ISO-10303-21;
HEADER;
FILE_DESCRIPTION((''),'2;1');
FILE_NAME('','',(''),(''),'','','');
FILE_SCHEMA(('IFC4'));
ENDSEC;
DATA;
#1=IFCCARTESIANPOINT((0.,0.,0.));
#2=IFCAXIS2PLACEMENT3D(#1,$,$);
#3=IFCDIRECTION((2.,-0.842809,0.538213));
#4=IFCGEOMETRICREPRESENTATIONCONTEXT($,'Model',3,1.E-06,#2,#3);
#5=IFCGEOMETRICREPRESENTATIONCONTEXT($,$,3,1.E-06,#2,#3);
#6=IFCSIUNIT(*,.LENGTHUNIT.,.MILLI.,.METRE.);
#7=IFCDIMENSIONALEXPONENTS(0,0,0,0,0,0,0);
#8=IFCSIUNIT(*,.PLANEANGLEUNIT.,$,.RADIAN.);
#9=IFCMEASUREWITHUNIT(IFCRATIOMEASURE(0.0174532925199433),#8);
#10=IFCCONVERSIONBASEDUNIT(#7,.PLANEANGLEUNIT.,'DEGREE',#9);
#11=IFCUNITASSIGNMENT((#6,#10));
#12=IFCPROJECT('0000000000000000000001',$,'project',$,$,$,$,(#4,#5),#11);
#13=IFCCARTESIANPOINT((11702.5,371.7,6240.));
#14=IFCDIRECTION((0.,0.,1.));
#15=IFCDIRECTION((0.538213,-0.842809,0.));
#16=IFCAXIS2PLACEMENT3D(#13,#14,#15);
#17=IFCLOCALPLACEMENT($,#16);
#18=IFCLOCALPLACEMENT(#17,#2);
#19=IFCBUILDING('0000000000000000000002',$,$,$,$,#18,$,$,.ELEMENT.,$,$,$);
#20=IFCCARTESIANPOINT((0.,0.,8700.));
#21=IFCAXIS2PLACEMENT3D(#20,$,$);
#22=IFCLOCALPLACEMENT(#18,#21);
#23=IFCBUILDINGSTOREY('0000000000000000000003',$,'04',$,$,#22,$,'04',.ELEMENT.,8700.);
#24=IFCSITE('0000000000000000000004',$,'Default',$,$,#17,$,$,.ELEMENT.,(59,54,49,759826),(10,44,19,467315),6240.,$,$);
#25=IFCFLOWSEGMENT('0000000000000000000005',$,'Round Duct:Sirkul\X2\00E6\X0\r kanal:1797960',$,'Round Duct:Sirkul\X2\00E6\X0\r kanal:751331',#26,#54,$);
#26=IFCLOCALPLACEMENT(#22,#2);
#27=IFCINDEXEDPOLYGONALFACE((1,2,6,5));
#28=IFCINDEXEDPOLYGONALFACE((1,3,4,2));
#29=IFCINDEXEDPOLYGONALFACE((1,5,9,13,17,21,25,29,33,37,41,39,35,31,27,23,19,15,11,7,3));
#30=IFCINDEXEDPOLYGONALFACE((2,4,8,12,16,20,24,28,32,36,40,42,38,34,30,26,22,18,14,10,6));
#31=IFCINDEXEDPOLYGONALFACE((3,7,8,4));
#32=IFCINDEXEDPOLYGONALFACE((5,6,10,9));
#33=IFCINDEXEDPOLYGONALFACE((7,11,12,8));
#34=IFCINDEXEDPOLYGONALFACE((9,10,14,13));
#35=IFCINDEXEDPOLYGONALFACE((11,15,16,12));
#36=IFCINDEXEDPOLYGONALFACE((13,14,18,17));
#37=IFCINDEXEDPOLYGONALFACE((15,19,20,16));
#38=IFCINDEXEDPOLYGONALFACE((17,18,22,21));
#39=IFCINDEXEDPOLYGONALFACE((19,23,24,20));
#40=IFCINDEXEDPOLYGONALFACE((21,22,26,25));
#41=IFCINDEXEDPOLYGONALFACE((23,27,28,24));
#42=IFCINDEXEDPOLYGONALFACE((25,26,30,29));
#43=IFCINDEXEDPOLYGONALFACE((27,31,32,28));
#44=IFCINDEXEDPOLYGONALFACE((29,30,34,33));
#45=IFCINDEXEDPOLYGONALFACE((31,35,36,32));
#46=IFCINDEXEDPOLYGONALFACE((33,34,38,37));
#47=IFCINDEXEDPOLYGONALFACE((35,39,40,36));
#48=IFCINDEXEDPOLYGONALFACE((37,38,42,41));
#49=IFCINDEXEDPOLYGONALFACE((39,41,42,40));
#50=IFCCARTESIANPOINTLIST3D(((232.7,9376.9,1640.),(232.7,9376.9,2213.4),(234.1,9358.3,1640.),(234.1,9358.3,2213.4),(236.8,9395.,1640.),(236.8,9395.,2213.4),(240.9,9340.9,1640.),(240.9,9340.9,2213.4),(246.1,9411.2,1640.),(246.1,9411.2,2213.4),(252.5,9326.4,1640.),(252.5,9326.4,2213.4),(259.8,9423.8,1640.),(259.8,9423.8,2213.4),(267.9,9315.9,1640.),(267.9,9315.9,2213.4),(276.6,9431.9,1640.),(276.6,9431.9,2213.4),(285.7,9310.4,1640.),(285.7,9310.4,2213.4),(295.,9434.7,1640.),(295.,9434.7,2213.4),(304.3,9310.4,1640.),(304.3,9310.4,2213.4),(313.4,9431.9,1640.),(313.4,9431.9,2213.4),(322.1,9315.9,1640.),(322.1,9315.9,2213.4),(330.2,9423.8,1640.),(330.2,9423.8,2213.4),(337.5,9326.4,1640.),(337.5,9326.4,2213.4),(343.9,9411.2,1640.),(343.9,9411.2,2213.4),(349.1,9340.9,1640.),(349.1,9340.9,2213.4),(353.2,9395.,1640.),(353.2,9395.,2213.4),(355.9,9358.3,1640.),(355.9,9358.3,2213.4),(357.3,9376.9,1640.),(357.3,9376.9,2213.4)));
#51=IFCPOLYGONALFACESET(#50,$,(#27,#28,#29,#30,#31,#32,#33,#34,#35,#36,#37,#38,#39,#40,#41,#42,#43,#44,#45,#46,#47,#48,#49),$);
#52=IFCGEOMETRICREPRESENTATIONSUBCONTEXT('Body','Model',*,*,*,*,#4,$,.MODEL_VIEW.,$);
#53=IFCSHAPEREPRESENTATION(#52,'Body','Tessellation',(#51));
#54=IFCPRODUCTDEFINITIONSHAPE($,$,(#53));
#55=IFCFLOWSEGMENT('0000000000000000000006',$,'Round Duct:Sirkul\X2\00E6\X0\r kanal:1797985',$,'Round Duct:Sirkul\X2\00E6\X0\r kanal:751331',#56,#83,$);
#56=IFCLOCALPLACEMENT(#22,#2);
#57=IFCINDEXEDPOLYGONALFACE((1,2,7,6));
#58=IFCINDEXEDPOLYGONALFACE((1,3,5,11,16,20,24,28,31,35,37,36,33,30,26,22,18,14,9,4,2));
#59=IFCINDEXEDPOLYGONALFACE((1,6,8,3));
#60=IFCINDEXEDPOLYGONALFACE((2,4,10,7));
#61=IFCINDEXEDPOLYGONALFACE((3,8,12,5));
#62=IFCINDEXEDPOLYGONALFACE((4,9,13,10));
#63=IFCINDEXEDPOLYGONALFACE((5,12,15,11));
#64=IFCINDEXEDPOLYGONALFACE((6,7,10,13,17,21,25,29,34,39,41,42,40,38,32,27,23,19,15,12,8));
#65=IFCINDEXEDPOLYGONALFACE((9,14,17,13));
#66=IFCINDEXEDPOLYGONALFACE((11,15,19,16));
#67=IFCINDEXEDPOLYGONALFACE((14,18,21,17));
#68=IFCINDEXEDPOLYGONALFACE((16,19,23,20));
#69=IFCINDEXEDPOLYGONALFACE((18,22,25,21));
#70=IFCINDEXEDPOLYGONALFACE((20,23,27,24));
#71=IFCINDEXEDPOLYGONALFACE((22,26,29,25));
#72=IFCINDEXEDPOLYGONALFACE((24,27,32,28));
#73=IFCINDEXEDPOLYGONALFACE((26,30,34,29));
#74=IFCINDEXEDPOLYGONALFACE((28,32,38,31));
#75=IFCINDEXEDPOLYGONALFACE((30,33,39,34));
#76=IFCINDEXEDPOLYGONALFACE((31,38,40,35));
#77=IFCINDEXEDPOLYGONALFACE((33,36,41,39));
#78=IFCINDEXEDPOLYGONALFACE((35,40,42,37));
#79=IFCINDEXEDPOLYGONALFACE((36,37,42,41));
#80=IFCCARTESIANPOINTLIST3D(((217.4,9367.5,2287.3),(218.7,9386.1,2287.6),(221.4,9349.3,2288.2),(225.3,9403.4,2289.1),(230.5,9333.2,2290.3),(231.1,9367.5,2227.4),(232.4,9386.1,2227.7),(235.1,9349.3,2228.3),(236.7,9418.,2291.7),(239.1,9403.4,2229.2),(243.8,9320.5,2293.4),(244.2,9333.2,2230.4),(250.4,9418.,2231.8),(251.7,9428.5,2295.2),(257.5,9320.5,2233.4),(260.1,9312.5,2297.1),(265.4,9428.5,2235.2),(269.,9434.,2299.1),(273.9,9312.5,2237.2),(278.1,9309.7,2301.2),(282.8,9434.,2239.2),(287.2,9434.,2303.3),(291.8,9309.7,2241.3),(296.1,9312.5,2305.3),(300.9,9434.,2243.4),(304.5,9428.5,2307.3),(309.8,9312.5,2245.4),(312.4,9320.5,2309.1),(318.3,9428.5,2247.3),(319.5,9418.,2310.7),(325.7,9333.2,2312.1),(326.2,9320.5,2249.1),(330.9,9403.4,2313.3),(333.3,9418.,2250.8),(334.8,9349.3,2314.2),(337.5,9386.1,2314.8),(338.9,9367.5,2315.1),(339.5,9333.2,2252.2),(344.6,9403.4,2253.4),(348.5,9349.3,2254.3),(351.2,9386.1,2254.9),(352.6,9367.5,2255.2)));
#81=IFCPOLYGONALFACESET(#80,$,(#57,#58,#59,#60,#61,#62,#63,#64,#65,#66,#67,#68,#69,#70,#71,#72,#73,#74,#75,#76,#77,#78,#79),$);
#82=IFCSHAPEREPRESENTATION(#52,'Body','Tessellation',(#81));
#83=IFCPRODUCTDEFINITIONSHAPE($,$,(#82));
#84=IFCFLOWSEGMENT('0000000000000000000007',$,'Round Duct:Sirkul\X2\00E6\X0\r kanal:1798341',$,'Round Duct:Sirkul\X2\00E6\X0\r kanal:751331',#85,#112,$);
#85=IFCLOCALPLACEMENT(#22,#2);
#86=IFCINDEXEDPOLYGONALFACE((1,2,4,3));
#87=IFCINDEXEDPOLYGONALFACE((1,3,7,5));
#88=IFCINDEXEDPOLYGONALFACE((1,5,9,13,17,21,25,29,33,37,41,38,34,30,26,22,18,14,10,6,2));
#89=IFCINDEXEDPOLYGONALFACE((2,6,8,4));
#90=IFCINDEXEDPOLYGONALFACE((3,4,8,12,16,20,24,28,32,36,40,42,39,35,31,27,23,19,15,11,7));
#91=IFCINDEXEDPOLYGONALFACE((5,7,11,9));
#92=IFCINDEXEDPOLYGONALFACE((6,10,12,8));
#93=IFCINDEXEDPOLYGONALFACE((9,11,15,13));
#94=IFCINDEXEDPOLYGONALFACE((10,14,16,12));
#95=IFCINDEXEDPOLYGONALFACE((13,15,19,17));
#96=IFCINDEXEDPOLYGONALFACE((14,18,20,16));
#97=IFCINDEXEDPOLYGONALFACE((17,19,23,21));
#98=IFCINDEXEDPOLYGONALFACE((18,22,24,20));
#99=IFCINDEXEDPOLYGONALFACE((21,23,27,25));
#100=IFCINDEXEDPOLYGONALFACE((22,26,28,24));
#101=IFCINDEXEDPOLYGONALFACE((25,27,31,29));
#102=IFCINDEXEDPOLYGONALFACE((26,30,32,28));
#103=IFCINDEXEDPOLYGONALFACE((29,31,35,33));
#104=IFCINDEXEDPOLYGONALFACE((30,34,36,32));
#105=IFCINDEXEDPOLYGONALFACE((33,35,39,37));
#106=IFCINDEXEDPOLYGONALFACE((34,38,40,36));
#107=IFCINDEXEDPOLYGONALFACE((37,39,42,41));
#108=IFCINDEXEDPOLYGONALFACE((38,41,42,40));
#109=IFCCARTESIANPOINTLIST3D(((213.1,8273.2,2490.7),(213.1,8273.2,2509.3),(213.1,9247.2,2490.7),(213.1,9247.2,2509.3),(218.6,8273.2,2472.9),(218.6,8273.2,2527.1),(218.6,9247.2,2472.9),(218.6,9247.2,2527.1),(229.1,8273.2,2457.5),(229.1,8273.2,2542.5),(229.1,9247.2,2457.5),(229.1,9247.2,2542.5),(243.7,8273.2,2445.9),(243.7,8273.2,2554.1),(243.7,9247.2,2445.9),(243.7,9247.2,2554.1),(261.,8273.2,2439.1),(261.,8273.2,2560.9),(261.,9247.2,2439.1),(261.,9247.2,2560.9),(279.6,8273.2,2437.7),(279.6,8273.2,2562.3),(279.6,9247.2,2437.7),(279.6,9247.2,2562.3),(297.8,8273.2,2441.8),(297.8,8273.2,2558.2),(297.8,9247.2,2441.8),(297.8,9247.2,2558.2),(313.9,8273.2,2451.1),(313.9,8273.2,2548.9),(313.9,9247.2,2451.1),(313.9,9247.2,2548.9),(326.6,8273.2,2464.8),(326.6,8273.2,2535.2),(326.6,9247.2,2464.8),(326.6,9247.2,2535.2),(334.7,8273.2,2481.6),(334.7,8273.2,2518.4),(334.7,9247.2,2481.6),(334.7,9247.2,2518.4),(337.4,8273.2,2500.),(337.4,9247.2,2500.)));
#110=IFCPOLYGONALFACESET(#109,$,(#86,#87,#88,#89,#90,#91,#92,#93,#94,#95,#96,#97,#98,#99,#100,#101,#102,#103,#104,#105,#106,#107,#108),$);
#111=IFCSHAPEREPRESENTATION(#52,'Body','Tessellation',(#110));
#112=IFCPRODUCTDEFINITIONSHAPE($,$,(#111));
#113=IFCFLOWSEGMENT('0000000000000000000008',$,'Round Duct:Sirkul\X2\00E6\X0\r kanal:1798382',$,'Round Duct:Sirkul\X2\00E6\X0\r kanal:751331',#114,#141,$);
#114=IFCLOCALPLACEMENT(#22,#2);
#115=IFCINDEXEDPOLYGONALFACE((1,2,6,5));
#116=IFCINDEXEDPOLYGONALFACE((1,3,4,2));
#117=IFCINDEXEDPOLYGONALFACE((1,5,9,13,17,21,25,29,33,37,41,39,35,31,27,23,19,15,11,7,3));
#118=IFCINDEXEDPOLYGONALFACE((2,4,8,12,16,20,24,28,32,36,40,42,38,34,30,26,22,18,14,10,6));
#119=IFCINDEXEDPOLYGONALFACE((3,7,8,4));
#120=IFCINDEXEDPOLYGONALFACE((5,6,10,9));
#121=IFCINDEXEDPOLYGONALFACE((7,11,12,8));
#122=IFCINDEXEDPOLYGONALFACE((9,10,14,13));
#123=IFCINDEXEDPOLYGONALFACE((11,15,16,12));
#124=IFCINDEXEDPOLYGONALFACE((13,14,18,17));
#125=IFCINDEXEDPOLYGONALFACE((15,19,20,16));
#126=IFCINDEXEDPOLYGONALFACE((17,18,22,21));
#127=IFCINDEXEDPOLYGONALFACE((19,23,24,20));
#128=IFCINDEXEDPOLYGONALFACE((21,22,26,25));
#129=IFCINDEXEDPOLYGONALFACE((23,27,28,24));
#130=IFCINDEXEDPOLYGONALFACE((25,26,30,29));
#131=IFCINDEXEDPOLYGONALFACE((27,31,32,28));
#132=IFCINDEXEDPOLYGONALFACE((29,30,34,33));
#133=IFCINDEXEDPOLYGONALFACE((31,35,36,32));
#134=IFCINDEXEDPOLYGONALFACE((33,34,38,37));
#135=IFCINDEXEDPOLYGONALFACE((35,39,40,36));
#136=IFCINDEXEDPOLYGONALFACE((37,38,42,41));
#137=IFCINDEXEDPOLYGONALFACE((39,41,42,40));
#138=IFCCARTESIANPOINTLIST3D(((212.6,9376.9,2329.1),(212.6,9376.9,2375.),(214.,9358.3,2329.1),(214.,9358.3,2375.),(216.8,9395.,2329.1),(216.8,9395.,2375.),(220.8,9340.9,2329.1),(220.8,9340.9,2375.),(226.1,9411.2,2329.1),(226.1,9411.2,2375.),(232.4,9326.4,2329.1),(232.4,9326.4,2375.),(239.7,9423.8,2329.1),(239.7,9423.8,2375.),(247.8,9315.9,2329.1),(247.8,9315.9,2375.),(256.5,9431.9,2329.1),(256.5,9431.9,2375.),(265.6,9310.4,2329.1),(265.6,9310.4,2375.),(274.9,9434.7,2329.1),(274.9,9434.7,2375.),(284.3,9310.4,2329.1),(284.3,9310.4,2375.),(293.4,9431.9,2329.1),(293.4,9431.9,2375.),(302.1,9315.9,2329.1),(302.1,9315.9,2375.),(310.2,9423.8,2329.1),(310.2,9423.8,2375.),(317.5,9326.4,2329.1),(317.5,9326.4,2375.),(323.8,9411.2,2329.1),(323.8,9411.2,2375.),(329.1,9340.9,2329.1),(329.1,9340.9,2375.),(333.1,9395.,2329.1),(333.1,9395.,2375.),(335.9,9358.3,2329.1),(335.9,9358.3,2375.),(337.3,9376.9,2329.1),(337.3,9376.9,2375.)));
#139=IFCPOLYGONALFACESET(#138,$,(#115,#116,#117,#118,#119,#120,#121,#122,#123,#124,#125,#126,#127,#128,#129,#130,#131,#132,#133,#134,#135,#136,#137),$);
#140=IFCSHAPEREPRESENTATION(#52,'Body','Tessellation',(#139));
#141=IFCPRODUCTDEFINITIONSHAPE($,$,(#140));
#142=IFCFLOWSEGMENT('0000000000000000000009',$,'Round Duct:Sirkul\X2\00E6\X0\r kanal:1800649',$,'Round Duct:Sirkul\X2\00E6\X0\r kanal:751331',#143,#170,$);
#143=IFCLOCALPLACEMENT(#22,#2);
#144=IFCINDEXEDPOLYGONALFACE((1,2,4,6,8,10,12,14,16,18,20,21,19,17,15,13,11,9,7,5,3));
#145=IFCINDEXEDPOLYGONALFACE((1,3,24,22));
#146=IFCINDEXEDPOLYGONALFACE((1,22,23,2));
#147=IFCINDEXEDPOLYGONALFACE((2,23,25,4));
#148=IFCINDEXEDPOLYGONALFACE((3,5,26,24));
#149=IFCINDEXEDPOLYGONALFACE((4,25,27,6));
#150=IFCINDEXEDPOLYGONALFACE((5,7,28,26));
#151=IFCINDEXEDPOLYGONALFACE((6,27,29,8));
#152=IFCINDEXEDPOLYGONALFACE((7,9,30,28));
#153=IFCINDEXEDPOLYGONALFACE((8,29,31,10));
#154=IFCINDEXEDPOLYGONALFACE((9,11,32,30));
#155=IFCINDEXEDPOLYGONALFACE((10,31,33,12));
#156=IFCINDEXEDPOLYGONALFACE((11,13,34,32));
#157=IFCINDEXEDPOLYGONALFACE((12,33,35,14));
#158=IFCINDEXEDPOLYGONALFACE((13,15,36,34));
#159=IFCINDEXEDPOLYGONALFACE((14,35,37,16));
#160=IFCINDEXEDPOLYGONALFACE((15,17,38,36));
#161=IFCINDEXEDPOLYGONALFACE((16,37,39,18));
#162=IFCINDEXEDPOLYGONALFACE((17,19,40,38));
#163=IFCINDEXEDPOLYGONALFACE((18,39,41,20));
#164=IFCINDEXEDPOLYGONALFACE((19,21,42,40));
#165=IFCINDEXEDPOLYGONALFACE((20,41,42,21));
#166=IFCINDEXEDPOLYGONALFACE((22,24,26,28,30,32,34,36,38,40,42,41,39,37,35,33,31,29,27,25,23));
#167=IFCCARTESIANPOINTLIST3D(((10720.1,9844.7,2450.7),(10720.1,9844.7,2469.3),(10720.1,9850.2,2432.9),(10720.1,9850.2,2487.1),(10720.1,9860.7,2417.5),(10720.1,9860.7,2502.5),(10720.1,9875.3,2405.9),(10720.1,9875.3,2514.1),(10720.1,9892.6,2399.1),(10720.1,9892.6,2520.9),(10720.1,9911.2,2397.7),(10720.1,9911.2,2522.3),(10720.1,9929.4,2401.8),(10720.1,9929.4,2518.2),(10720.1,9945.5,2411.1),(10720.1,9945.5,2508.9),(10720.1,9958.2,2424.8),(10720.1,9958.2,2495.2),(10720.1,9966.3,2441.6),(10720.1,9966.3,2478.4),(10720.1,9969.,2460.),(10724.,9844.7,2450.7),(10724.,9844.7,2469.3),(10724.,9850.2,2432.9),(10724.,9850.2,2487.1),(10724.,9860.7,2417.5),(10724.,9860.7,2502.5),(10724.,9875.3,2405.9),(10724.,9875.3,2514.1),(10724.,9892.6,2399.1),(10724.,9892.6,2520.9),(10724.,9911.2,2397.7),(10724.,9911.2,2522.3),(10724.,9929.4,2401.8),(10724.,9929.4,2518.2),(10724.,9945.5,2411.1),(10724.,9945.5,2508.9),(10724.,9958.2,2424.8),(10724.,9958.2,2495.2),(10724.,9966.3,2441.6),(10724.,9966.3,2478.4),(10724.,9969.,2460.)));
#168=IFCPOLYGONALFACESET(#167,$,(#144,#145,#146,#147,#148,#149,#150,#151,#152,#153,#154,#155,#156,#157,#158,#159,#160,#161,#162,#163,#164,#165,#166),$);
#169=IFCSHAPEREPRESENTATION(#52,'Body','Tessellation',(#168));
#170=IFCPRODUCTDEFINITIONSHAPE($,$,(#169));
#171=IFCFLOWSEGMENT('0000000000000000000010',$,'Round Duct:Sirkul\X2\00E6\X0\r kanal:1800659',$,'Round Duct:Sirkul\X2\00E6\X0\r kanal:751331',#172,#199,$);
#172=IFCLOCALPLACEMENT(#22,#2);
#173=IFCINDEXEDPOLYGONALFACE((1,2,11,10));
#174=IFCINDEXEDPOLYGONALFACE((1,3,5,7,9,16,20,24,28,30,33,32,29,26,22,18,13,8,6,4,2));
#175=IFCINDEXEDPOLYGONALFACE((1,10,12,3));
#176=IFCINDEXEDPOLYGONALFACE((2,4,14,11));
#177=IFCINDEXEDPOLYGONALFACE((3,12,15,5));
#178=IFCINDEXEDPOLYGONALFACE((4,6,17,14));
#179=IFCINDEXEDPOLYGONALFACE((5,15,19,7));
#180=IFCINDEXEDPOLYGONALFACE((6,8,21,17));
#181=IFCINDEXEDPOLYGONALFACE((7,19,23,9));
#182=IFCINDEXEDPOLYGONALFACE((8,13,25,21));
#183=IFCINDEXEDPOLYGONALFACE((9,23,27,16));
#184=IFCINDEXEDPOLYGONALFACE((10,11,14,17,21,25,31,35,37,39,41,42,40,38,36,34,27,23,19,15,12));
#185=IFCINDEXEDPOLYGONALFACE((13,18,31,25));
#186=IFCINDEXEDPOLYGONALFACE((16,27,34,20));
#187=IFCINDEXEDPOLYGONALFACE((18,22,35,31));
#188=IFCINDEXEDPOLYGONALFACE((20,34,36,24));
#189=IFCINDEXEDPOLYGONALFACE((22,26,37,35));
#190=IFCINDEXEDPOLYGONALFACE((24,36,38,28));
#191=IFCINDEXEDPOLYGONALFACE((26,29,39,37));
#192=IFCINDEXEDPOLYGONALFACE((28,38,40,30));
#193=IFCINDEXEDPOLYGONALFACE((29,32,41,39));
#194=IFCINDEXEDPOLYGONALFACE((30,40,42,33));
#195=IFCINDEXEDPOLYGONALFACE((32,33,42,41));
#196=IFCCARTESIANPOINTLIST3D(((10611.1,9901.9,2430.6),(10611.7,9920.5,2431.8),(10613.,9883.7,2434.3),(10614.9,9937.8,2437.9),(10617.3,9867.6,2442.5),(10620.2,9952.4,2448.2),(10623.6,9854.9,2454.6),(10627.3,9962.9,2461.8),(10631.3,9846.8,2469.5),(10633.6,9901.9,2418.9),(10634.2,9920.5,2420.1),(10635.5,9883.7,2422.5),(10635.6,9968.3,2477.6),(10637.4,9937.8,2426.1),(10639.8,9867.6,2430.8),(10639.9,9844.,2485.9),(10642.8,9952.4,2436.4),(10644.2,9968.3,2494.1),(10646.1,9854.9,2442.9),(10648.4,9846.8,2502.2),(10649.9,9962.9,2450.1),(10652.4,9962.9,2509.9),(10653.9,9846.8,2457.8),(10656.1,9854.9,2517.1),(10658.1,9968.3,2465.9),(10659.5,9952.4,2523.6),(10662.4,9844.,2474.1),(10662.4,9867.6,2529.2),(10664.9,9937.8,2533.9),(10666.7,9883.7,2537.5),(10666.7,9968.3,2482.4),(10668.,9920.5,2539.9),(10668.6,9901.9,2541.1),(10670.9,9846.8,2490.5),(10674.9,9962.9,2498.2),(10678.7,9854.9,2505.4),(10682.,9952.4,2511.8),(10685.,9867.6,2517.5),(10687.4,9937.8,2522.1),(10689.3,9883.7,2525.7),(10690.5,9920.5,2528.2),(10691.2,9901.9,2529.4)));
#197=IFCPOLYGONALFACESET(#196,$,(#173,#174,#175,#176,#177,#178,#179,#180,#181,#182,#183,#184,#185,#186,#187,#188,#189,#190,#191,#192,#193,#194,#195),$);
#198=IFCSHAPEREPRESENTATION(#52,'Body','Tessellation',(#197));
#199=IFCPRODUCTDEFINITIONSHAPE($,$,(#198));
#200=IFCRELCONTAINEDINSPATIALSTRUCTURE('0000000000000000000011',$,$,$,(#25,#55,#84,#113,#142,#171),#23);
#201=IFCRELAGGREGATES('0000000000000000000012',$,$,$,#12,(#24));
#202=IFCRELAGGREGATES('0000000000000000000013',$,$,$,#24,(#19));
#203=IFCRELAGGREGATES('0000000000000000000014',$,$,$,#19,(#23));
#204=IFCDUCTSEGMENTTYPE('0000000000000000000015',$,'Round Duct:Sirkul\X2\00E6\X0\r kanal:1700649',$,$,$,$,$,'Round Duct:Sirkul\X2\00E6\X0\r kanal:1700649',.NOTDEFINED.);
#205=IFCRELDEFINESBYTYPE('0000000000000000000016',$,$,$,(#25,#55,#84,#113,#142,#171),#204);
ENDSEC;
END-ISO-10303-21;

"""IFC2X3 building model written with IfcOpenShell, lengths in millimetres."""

from ifc_helpers import new_model, entity, si_unit, converted_unit, direction, frame, frame_2d, origin, origin_2d_with_axis, place, context, subcontext, project, spatial, circle, extrude, type_object, element, save


model = new_model("IFC2X3")

# Units and contexts
model_context = context("Model", 3, precision=1e-06, world=origin(), true_north=direction((2.0, -0.842809, 0.538213)))
context_of_model = context(None, 3, precision=1e-06, world=origin(), true_north=direction((2.0, -0.842809, 0.538213)))
body_context = subcontext(model_context, "Body", "Model", "MODEL_VIEW")
ifc_project = project(units=[si_unit("LENGTHUNIT", "METRE", prefix="MILLI"), converted_unit("PLANEANGLEUNIT", "DEGREE", entity("IfcRatioMeasure", 0.0174532925199433), si_unit("PLANEANGLEUNIT", "RADIAN"), dimensions=[0, 0, 0, 0, 0, 0, 0])], contexts=[model_context, context_of_model])

# Site, building, storey
site_placement = place(None, frame((11702.5, 371.7, 6240.0), z_axis=(0.0, 0.0, 1.0), x_axis=(0.538213, -0.842809, 0.0)))
site = spatial("IfcSite", under=ifc_project, at=site_placement, Name="Default", CompositionType="ELEMENT", RefLatitude=(59, 54, 49, 759826), RefLongitude=(10, 44, 19, 467315), RefElevation=6240.0)
building_placement = place(site_placement, origin())
building = spatial("IfcBuilding", under=site, at=building_placement, CompositionType="ELEMENT")
storey_placement = place(building_placement, frame((0.0, 0.0, 8700.0)))
storey = spatial("IfcBuildingStorey", under=building, at=storey_placement, Name="04", LongName="04", CompositionType="ELEMENT", Elevation=8700.0)

# Flow segments
duct_segment_type = type_object("IfcDuctSegmentType", Name="Round Duct:Sirkulær kanal:1700649", ElementType="Round Duct:Sirkulær kanal:1700649", PredefinedType="NOTDEFINED")
flow_segment_1_placement = place(storey_placement, origin())
element("IfcFlowSegment", 1, at=flow_segment_1_placement, inside=storey, type_object=duct_segment_type, Name="Round Duct:Sirkulær kanal:1797960", ObjectType="Round Duct:Sirkulær kanal:751331", context=body_context, shape_type="SweptSolid", body=[
    extrude(circle(Radius=62.5, at=frame_2d((0.0, 0.0), x_axis=(1.0, 0.0))), frame((295.0, 9372.2, 1640.0), z_axis=(0.0, 0.0, 1.0), x_axis=(0.0, 1.0, 0.0)), (0.0, 0.0, 1.0), 573.4),
])
flow_segment_2_placement = place(storey_placement, origin())
element("IfcFlowSegment", 2, at=flow_segment_2_placement, inside=storey, type_object=duct_segment_type, Name="Round Duct:Sirkulær kanal:1797985", ObjectType="Round Duct:Sirkulær kanal:751331", context=body_context, shape_type="SweptSolid", body=[
    extrude(circle(Radius=62.5, at=frame_2d((0.0, 0.0), x_axis=(1.0, 0.0))), frame((291.8, 9372.2, 2241.3), z_axis=(-0.223272, 0.0, 0.974756), x_axis=(0.0, -1.0, 0.0)), (0.0, 0.0, 1.0), 61.5),
])
flow_segment_3_placement = place(storey_placement, origin())
element("IfcFlowSegment", 3, at=flow_segment_3_placement, inside=storey, type_object=duct_segment_type, Name="Round Duct:Sirkulær kanal:1798341", ObjectType="Round Duct:Sirkulær kanal:751331", context=body_context, shape_type="SweptSolid", body=[
    extrude(circle(Radius=62.5, at=frame_2d((0.0, 0.0), x_axis=(1.0, 0.0))), frame((274.9, 8273.2, 2500.0), z_axis=(0.0, 1.0, 0.0), x_axis=(1.0, 0.0, 0.0)), (0.0, 0.0, 1.0), 974.0),
])
flow_segment_4_placement = place(storey_placement, origin())
element("IfcFlowSegment", 4, at=flow_segment_4_placement, inside=storey, type_object=duct_segment_type, Name="Round Duct:Sirkulær kanal:1798382", ObjectType="Round Duct:Sirkulær kanal:751331", context=body_context, shape_type="SweptSolid", body=[
    extrude(circle(Radius=62.5, at=frame_2d((0.0, 0.0), x_axis=(1.0, 0.0))), frame((274.9, 9372.2, 2329.1), z_axis=(0.0, 0.0, 1.0), x_axis=(0.0, 1.0, 0.0)), (0.0, 0.0, 1.0), 45.9),
])
flow_segment_5_placement = place(storey_placement, origin())
element("IfcFlowSegment", 5, at=flow_segment_5_placement, inside=storey, type_object=duct_segment_type, Name="Round Duct:Sirkulær kanal:1800649", ObjectType="Round Duct:Sirkulær kanal:751331", context=body_context, shape_type="SweptSolid", body=[
    extrude(circle(Radius=62.5, at=origin_2d_with_axis()), frame((10720.1, 9906.5, 2460.0), z_axis=(1.0, 0.0, 0.0), x_axis=(0.0, 1.0, 0.0)), (0.0, 0.0, 1.0), 3.8),
])
flow_segment_6_placement = place(storey_placement, origin())
element("IfcFlowSegment", 6, at=flow_segment_6_placement, inside=storey, type_object=duct_segment_type, Name="Round Duct:Sirkulær kanal:1800659", ObjectType="Round Duct:Sirkulær kanal:751331", context=body_context, shape_type="SweptSolid", body=[
    extrude(circle(Radius=62.5, at=origin_2d_with_axis()), frame((10639.9, 9906.5, 2485.9), z_axis=(0.886943, 0.0, -0.461878), x_axis=(0.0, -1.0, 0.0)), (0.0, 0.0, 1.0), 25.4),
])

save(model, "model.ifc")
